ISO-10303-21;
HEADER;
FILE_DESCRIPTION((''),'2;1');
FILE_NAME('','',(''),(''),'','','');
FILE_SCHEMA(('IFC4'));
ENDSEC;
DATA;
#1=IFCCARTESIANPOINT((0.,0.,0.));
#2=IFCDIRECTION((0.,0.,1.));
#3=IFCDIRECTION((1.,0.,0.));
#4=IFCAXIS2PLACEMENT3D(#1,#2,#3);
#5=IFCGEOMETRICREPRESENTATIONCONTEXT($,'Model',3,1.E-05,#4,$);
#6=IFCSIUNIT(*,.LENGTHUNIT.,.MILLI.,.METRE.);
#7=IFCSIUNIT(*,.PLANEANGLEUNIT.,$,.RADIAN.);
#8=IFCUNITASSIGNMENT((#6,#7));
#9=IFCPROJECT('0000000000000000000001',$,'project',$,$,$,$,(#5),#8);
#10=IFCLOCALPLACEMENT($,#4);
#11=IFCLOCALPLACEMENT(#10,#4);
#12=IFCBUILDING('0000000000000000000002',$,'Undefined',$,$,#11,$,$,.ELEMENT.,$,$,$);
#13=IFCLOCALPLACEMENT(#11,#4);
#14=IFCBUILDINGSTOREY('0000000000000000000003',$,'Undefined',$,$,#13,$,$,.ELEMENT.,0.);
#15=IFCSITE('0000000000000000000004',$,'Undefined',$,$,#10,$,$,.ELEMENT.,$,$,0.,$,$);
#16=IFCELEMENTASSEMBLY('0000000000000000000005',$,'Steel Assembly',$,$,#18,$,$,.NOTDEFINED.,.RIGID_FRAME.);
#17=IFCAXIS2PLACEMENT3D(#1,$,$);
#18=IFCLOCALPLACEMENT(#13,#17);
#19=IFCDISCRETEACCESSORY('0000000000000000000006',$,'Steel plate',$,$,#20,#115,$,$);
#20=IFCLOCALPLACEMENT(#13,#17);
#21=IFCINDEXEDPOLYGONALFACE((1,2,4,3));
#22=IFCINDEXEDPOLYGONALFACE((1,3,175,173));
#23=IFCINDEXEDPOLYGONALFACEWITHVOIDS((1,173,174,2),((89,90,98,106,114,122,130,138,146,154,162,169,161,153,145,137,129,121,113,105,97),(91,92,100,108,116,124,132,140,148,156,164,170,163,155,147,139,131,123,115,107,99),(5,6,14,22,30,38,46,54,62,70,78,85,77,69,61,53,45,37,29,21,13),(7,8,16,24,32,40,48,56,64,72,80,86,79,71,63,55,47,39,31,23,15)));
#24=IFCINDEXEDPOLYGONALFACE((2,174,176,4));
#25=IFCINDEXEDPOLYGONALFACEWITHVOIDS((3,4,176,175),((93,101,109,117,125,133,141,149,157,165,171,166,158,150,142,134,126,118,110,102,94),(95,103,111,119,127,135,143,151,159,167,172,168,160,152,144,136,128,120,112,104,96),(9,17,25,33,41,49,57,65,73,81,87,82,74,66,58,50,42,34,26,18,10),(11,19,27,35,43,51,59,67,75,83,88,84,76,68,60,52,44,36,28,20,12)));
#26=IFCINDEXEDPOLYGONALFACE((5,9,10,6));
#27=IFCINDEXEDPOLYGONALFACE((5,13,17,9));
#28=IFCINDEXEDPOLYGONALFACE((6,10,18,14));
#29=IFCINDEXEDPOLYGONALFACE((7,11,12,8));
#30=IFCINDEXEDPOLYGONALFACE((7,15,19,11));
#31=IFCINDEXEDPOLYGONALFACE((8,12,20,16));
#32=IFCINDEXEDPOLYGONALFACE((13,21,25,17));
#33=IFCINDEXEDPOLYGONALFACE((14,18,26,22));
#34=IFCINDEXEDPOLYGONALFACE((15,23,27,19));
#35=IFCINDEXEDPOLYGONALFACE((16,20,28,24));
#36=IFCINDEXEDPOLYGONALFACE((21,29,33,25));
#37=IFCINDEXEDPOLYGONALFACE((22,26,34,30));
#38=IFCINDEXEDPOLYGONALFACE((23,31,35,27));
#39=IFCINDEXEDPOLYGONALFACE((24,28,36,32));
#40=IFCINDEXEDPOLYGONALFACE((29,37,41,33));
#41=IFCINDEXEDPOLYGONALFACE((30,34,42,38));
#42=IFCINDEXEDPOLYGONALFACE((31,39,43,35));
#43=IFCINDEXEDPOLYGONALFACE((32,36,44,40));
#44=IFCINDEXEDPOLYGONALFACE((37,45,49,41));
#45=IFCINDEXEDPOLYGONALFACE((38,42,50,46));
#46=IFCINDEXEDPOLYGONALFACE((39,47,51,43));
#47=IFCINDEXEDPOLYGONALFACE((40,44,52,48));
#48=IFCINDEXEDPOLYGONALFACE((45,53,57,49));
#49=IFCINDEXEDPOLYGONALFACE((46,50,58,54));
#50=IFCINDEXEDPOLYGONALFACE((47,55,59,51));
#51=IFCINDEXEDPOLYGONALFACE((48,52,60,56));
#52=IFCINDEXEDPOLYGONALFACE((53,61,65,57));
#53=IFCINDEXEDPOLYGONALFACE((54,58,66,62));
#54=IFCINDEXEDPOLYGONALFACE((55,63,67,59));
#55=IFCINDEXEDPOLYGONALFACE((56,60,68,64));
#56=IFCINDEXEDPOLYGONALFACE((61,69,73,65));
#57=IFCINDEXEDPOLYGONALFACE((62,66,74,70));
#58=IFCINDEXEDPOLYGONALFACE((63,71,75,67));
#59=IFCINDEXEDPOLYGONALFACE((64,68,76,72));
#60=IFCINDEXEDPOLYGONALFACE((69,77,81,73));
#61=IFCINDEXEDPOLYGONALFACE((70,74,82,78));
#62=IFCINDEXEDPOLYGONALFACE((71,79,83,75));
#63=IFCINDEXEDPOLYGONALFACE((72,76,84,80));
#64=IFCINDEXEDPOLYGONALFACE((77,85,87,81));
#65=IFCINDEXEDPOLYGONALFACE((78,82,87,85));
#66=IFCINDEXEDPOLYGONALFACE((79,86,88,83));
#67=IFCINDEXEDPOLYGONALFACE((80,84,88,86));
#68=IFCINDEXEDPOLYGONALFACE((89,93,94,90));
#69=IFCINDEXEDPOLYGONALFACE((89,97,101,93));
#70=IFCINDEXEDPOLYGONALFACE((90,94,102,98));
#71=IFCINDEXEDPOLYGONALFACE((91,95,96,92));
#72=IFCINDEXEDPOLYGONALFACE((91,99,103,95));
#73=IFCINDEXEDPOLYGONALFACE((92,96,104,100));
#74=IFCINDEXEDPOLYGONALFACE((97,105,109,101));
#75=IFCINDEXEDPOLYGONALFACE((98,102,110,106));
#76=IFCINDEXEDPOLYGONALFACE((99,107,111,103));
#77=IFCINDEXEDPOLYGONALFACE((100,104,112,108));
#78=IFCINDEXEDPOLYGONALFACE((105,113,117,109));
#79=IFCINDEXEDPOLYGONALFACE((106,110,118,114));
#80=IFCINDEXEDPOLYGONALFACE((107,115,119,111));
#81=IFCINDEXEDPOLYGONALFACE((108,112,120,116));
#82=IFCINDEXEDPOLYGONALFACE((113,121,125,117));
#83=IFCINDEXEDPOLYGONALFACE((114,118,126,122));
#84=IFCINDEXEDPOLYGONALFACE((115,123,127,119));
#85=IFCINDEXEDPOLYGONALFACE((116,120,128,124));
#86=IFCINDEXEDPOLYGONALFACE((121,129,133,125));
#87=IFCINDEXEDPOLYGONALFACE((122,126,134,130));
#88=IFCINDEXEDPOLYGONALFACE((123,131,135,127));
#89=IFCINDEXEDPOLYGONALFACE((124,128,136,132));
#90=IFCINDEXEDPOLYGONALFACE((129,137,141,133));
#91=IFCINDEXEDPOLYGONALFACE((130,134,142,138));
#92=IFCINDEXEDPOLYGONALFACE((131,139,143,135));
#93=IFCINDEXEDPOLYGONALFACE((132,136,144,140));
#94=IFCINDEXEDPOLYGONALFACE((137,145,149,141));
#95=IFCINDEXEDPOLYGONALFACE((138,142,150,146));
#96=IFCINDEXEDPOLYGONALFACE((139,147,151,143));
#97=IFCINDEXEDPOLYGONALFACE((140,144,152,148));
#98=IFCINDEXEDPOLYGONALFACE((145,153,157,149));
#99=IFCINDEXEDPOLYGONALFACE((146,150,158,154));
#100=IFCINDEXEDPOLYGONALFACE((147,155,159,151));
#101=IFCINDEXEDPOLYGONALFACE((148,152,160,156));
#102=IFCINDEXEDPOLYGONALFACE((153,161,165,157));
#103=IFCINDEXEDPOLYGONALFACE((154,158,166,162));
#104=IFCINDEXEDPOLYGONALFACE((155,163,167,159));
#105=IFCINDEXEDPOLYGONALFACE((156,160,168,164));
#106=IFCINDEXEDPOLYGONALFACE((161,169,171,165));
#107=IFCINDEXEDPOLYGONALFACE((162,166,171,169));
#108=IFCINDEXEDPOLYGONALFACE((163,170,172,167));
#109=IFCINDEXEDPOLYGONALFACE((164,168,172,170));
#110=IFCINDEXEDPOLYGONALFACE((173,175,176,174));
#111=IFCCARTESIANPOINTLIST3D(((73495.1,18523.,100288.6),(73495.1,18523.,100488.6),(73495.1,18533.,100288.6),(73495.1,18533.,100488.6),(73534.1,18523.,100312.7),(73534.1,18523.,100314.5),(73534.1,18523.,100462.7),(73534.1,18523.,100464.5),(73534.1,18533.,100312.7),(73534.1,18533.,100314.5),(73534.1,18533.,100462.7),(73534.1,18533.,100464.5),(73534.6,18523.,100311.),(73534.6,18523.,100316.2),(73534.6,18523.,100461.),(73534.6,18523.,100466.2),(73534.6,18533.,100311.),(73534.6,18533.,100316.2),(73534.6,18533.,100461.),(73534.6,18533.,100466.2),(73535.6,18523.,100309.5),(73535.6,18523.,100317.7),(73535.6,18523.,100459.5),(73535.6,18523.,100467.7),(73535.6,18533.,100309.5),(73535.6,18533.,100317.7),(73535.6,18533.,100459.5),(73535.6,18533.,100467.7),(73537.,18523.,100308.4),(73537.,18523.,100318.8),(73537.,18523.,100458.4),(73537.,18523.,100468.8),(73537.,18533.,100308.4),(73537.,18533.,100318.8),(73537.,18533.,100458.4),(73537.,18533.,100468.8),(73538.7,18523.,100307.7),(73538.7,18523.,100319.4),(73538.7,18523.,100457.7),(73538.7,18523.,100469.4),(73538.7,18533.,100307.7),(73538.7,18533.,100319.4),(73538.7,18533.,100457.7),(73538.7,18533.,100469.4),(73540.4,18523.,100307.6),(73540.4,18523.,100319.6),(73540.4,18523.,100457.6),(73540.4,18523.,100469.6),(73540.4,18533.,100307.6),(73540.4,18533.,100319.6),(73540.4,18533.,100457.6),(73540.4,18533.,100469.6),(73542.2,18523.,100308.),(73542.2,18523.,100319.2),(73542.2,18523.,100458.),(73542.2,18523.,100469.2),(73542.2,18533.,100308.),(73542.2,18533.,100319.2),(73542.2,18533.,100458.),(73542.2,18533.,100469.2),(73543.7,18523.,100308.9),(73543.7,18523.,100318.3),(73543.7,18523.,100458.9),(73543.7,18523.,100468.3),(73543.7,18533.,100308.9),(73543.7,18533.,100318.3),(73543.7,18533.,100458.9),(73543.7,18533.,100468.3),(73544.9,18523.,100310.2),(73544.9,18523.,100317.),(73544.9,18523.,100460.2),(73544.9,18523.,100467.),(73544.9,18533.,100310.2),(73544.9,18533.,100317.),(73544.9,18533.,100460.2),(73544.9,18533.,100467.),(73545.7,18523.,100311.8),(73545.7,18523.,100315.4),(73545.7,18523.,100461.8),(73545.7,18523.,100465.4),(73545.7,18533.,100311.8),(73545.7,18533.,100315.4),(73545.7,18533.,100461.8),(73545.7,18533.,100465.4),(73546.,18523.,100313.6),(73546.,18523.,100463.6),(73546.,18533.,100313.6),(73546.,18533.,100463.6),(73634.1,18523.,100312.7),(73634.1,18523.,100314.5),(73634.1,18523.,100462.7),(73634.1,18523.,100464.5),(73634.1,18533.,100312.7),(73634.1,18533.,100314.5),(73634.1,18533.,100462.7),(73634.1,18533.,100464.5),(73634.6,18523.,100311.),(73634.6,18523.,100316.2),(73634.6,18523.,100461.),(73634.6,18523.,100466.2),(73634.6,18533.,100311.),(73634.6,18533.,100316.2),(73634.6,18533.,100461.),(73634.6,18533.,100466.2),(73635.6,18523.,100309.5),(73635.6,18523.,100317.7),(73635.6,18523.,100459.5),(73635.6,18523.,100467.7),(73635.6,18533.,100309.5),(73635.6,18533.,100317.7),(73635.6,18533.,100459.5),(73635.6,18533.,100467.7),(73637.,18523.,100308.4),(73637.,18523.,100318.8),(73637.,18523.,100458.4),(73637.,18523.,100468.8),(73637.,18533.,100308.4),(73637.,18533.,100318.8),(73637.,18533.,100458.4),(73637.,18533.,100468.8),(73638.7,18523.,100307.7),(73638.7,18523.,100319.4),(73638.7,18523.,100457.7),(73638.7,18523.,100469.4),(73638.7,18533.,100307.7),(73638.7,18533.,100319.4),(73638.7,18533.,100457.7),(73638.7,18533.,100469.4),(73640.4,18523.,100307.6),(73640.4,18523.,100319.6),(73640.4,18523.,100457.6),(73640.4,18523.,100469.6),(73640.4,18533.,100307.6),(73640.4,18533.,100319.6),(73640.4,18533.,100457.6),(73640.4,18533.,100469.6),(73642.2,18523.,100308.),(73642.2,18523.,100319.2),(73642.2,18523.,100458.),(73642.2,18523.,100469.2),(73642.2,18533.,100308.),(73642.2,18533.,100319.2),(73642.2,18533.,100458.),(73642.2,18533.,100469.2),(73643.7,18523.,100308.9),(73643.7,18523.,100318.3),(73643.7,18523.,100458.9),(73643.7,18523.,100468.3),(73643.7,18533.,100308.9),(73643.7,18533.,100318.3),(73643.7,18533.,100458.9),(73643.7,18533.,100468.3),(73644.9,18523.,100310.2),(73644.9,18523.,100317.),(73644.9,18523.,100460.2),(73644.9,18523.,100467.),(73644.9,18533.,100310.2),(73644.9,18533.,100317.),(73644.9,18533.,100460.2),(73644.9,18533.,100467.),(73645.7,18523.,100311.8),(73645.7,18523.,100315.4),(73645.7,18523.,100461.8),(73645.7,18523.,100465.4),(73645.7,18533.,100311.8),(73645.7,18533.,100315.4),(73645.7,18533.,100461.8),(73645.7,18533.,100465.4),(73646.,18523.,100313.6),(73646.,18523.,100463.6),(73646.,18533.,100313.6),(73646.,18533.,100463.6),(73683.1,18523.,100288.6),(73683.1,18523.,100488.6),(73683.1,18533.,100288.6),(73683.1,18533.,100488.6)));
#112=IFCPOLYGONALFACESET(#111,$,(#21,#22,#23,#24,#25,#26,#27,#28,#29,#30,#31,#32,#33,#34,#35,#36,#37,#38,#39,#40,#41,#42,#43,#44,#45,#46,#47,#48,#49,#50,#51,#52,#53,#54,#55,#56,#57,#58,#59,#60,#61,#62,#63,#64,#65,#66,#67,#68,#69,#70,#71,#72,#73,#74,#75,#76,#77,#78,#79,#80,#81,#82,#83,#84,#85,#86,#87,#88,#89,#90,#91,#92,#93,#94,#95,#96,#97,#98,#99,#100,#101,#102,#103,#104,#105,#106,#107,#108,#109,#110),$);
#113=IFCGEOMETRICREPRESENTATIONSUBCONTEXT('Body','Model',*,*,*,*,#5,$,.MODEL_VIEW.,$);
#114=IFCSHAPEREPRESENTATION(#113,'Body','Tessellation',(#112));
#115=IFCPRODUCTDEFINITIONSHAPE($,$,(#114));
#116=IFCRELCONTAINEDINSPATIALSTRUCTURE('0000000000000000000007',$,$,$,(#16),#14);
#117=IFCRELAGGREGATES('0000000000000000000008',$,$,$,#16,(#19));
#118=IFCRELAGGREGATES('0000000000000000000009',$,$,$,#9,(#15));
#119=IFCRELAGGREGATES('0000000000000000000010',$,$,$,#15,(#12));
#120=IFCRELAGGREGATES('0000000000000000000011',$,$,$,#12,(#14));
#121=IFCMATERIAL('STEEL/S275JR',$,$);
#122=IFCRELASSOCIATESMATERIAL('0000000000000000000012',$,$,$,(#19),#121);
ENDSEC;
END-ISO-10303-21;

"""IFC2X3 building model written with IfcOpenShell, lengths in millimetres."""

from ifc_helpers import new_model, si_unit, frame, origin_with_axes, origin_2d_with_axis, place, context, subcontext, project, spatial, polyline, circle, outline, extrude, source, transform, mapped, material, element, aggregate, save


model = new_model("IFC2X3")

# Units and contexts
model_context = context("Model", 3, precision=1e-05, world=origin_with_axes())
body_context = subcontext(model_context, "Body", "Model", "MODEL_VIEW")
ifc_project = project(units=[si_unit("LENGTHUNIT", "METRE", prefix="MILLI"), si_unit("PLANEANGLEUNIT", "RADIAN")], contexts=[model_context])

# Site, building, storey
site_placement = place(None, origin_with_axes())
site = spatial("IfcSite", under=ifc_project, at=site_placement, Name="Undefined", CompositionType="ELEMENT", RefElevation=0.0)
building_placement = place(site_placement, origin_with_axes())
building = spatial("IfcBuilding", under=site, at=building_placement, Name="Undefined", CompositionType="ELEMENT")
storey_placement = place(building_placement, origin_with_axes())
storey = spatial("IfcBuildingStorey", under=building, at=storey_placement, Name="Undefined", CompositionType="ELEMENT", Elevation=0.0)

# Element assembly
assembly_1_placement = place(storey_placement, origin_with_axes())
assembly_1 = element("IfcElementAssembly", 1, at=assembly_1_placement, inside=storey, Name="Steel Assembly", AssemblyPlace="NOTDEFINED", PredefinedType="RIGID_FRAME")

# Discrete accessory, opening
ifc_material_1 = material(Name="STEEL/S275JR")
shared_shape_1 = source(origin_with_axes(), body_context, "Body", "SweptSolid", [
    extrude(circle(Radius=6.0, at=origin_2d_with_axis()), frame((0.0, -0.2, 0.0), z_axis=(0.0, 1.0, 0.0), x_axis=(1.0, 0.0, 0.0)), (0.0, 0.0, 1.0), 10.2),
])
discrete_accessory_1_placement = place(assembly_1_placement, frame((73683.1, 18528.0, 100488.6), z_axis=(0.0, -1.0, 0.0), x_axis=(-1.0, 0.0, 0.0)))
discrete_accessory_1 = element("IfcDiscreteAccessory", 2, at=discrete_accessory_1_placement, material=ifc_material_1, Name="Steel plate", context=body_context, shape_type="SweptSolid", body=[
    extrude(outline(polyline([(0.0, 0.0), (188.0, 0.0), (188.0, 200.0), (0.0, 200.0), (0.0, 0.0)])), frame((0.0, 0.0, -5.0), z_axis=(0.0, 0.0, 1.0), x_axis=(1.0, 0.0, 0.0)), (0.0, 0.0, 1.0), 10.0),
])
opening_1_placement = place(assembly_1_placement, frame((73540.0, 18523.1, 100388.6), z_axis=(0.0, 0.0, 1.0), x_axis=(1.0, 0.0, 0.0)))
element("IfcOpeningElement", 3, at=opening_1_placement, cuts=discrete_accessory_1, ObjectType="Opening", context=body_context, shape_type="MappedRepresentation", body=[
    mapped(shared_shape_1, transform((0.0, 0.0, -75.0))),
    mapped(shared_shape_1, transform((100.0, 0.0, -75.0))),
    mapped(shared_shape_1, transform((0.0, 0.0, 75.0))),
    mapped(shared_shape_1, transform((100.0, 0.0, 75.0))),
])

aggregate(assembly_1, [discrete_accessory_1])

save(model, "model.ifc")
